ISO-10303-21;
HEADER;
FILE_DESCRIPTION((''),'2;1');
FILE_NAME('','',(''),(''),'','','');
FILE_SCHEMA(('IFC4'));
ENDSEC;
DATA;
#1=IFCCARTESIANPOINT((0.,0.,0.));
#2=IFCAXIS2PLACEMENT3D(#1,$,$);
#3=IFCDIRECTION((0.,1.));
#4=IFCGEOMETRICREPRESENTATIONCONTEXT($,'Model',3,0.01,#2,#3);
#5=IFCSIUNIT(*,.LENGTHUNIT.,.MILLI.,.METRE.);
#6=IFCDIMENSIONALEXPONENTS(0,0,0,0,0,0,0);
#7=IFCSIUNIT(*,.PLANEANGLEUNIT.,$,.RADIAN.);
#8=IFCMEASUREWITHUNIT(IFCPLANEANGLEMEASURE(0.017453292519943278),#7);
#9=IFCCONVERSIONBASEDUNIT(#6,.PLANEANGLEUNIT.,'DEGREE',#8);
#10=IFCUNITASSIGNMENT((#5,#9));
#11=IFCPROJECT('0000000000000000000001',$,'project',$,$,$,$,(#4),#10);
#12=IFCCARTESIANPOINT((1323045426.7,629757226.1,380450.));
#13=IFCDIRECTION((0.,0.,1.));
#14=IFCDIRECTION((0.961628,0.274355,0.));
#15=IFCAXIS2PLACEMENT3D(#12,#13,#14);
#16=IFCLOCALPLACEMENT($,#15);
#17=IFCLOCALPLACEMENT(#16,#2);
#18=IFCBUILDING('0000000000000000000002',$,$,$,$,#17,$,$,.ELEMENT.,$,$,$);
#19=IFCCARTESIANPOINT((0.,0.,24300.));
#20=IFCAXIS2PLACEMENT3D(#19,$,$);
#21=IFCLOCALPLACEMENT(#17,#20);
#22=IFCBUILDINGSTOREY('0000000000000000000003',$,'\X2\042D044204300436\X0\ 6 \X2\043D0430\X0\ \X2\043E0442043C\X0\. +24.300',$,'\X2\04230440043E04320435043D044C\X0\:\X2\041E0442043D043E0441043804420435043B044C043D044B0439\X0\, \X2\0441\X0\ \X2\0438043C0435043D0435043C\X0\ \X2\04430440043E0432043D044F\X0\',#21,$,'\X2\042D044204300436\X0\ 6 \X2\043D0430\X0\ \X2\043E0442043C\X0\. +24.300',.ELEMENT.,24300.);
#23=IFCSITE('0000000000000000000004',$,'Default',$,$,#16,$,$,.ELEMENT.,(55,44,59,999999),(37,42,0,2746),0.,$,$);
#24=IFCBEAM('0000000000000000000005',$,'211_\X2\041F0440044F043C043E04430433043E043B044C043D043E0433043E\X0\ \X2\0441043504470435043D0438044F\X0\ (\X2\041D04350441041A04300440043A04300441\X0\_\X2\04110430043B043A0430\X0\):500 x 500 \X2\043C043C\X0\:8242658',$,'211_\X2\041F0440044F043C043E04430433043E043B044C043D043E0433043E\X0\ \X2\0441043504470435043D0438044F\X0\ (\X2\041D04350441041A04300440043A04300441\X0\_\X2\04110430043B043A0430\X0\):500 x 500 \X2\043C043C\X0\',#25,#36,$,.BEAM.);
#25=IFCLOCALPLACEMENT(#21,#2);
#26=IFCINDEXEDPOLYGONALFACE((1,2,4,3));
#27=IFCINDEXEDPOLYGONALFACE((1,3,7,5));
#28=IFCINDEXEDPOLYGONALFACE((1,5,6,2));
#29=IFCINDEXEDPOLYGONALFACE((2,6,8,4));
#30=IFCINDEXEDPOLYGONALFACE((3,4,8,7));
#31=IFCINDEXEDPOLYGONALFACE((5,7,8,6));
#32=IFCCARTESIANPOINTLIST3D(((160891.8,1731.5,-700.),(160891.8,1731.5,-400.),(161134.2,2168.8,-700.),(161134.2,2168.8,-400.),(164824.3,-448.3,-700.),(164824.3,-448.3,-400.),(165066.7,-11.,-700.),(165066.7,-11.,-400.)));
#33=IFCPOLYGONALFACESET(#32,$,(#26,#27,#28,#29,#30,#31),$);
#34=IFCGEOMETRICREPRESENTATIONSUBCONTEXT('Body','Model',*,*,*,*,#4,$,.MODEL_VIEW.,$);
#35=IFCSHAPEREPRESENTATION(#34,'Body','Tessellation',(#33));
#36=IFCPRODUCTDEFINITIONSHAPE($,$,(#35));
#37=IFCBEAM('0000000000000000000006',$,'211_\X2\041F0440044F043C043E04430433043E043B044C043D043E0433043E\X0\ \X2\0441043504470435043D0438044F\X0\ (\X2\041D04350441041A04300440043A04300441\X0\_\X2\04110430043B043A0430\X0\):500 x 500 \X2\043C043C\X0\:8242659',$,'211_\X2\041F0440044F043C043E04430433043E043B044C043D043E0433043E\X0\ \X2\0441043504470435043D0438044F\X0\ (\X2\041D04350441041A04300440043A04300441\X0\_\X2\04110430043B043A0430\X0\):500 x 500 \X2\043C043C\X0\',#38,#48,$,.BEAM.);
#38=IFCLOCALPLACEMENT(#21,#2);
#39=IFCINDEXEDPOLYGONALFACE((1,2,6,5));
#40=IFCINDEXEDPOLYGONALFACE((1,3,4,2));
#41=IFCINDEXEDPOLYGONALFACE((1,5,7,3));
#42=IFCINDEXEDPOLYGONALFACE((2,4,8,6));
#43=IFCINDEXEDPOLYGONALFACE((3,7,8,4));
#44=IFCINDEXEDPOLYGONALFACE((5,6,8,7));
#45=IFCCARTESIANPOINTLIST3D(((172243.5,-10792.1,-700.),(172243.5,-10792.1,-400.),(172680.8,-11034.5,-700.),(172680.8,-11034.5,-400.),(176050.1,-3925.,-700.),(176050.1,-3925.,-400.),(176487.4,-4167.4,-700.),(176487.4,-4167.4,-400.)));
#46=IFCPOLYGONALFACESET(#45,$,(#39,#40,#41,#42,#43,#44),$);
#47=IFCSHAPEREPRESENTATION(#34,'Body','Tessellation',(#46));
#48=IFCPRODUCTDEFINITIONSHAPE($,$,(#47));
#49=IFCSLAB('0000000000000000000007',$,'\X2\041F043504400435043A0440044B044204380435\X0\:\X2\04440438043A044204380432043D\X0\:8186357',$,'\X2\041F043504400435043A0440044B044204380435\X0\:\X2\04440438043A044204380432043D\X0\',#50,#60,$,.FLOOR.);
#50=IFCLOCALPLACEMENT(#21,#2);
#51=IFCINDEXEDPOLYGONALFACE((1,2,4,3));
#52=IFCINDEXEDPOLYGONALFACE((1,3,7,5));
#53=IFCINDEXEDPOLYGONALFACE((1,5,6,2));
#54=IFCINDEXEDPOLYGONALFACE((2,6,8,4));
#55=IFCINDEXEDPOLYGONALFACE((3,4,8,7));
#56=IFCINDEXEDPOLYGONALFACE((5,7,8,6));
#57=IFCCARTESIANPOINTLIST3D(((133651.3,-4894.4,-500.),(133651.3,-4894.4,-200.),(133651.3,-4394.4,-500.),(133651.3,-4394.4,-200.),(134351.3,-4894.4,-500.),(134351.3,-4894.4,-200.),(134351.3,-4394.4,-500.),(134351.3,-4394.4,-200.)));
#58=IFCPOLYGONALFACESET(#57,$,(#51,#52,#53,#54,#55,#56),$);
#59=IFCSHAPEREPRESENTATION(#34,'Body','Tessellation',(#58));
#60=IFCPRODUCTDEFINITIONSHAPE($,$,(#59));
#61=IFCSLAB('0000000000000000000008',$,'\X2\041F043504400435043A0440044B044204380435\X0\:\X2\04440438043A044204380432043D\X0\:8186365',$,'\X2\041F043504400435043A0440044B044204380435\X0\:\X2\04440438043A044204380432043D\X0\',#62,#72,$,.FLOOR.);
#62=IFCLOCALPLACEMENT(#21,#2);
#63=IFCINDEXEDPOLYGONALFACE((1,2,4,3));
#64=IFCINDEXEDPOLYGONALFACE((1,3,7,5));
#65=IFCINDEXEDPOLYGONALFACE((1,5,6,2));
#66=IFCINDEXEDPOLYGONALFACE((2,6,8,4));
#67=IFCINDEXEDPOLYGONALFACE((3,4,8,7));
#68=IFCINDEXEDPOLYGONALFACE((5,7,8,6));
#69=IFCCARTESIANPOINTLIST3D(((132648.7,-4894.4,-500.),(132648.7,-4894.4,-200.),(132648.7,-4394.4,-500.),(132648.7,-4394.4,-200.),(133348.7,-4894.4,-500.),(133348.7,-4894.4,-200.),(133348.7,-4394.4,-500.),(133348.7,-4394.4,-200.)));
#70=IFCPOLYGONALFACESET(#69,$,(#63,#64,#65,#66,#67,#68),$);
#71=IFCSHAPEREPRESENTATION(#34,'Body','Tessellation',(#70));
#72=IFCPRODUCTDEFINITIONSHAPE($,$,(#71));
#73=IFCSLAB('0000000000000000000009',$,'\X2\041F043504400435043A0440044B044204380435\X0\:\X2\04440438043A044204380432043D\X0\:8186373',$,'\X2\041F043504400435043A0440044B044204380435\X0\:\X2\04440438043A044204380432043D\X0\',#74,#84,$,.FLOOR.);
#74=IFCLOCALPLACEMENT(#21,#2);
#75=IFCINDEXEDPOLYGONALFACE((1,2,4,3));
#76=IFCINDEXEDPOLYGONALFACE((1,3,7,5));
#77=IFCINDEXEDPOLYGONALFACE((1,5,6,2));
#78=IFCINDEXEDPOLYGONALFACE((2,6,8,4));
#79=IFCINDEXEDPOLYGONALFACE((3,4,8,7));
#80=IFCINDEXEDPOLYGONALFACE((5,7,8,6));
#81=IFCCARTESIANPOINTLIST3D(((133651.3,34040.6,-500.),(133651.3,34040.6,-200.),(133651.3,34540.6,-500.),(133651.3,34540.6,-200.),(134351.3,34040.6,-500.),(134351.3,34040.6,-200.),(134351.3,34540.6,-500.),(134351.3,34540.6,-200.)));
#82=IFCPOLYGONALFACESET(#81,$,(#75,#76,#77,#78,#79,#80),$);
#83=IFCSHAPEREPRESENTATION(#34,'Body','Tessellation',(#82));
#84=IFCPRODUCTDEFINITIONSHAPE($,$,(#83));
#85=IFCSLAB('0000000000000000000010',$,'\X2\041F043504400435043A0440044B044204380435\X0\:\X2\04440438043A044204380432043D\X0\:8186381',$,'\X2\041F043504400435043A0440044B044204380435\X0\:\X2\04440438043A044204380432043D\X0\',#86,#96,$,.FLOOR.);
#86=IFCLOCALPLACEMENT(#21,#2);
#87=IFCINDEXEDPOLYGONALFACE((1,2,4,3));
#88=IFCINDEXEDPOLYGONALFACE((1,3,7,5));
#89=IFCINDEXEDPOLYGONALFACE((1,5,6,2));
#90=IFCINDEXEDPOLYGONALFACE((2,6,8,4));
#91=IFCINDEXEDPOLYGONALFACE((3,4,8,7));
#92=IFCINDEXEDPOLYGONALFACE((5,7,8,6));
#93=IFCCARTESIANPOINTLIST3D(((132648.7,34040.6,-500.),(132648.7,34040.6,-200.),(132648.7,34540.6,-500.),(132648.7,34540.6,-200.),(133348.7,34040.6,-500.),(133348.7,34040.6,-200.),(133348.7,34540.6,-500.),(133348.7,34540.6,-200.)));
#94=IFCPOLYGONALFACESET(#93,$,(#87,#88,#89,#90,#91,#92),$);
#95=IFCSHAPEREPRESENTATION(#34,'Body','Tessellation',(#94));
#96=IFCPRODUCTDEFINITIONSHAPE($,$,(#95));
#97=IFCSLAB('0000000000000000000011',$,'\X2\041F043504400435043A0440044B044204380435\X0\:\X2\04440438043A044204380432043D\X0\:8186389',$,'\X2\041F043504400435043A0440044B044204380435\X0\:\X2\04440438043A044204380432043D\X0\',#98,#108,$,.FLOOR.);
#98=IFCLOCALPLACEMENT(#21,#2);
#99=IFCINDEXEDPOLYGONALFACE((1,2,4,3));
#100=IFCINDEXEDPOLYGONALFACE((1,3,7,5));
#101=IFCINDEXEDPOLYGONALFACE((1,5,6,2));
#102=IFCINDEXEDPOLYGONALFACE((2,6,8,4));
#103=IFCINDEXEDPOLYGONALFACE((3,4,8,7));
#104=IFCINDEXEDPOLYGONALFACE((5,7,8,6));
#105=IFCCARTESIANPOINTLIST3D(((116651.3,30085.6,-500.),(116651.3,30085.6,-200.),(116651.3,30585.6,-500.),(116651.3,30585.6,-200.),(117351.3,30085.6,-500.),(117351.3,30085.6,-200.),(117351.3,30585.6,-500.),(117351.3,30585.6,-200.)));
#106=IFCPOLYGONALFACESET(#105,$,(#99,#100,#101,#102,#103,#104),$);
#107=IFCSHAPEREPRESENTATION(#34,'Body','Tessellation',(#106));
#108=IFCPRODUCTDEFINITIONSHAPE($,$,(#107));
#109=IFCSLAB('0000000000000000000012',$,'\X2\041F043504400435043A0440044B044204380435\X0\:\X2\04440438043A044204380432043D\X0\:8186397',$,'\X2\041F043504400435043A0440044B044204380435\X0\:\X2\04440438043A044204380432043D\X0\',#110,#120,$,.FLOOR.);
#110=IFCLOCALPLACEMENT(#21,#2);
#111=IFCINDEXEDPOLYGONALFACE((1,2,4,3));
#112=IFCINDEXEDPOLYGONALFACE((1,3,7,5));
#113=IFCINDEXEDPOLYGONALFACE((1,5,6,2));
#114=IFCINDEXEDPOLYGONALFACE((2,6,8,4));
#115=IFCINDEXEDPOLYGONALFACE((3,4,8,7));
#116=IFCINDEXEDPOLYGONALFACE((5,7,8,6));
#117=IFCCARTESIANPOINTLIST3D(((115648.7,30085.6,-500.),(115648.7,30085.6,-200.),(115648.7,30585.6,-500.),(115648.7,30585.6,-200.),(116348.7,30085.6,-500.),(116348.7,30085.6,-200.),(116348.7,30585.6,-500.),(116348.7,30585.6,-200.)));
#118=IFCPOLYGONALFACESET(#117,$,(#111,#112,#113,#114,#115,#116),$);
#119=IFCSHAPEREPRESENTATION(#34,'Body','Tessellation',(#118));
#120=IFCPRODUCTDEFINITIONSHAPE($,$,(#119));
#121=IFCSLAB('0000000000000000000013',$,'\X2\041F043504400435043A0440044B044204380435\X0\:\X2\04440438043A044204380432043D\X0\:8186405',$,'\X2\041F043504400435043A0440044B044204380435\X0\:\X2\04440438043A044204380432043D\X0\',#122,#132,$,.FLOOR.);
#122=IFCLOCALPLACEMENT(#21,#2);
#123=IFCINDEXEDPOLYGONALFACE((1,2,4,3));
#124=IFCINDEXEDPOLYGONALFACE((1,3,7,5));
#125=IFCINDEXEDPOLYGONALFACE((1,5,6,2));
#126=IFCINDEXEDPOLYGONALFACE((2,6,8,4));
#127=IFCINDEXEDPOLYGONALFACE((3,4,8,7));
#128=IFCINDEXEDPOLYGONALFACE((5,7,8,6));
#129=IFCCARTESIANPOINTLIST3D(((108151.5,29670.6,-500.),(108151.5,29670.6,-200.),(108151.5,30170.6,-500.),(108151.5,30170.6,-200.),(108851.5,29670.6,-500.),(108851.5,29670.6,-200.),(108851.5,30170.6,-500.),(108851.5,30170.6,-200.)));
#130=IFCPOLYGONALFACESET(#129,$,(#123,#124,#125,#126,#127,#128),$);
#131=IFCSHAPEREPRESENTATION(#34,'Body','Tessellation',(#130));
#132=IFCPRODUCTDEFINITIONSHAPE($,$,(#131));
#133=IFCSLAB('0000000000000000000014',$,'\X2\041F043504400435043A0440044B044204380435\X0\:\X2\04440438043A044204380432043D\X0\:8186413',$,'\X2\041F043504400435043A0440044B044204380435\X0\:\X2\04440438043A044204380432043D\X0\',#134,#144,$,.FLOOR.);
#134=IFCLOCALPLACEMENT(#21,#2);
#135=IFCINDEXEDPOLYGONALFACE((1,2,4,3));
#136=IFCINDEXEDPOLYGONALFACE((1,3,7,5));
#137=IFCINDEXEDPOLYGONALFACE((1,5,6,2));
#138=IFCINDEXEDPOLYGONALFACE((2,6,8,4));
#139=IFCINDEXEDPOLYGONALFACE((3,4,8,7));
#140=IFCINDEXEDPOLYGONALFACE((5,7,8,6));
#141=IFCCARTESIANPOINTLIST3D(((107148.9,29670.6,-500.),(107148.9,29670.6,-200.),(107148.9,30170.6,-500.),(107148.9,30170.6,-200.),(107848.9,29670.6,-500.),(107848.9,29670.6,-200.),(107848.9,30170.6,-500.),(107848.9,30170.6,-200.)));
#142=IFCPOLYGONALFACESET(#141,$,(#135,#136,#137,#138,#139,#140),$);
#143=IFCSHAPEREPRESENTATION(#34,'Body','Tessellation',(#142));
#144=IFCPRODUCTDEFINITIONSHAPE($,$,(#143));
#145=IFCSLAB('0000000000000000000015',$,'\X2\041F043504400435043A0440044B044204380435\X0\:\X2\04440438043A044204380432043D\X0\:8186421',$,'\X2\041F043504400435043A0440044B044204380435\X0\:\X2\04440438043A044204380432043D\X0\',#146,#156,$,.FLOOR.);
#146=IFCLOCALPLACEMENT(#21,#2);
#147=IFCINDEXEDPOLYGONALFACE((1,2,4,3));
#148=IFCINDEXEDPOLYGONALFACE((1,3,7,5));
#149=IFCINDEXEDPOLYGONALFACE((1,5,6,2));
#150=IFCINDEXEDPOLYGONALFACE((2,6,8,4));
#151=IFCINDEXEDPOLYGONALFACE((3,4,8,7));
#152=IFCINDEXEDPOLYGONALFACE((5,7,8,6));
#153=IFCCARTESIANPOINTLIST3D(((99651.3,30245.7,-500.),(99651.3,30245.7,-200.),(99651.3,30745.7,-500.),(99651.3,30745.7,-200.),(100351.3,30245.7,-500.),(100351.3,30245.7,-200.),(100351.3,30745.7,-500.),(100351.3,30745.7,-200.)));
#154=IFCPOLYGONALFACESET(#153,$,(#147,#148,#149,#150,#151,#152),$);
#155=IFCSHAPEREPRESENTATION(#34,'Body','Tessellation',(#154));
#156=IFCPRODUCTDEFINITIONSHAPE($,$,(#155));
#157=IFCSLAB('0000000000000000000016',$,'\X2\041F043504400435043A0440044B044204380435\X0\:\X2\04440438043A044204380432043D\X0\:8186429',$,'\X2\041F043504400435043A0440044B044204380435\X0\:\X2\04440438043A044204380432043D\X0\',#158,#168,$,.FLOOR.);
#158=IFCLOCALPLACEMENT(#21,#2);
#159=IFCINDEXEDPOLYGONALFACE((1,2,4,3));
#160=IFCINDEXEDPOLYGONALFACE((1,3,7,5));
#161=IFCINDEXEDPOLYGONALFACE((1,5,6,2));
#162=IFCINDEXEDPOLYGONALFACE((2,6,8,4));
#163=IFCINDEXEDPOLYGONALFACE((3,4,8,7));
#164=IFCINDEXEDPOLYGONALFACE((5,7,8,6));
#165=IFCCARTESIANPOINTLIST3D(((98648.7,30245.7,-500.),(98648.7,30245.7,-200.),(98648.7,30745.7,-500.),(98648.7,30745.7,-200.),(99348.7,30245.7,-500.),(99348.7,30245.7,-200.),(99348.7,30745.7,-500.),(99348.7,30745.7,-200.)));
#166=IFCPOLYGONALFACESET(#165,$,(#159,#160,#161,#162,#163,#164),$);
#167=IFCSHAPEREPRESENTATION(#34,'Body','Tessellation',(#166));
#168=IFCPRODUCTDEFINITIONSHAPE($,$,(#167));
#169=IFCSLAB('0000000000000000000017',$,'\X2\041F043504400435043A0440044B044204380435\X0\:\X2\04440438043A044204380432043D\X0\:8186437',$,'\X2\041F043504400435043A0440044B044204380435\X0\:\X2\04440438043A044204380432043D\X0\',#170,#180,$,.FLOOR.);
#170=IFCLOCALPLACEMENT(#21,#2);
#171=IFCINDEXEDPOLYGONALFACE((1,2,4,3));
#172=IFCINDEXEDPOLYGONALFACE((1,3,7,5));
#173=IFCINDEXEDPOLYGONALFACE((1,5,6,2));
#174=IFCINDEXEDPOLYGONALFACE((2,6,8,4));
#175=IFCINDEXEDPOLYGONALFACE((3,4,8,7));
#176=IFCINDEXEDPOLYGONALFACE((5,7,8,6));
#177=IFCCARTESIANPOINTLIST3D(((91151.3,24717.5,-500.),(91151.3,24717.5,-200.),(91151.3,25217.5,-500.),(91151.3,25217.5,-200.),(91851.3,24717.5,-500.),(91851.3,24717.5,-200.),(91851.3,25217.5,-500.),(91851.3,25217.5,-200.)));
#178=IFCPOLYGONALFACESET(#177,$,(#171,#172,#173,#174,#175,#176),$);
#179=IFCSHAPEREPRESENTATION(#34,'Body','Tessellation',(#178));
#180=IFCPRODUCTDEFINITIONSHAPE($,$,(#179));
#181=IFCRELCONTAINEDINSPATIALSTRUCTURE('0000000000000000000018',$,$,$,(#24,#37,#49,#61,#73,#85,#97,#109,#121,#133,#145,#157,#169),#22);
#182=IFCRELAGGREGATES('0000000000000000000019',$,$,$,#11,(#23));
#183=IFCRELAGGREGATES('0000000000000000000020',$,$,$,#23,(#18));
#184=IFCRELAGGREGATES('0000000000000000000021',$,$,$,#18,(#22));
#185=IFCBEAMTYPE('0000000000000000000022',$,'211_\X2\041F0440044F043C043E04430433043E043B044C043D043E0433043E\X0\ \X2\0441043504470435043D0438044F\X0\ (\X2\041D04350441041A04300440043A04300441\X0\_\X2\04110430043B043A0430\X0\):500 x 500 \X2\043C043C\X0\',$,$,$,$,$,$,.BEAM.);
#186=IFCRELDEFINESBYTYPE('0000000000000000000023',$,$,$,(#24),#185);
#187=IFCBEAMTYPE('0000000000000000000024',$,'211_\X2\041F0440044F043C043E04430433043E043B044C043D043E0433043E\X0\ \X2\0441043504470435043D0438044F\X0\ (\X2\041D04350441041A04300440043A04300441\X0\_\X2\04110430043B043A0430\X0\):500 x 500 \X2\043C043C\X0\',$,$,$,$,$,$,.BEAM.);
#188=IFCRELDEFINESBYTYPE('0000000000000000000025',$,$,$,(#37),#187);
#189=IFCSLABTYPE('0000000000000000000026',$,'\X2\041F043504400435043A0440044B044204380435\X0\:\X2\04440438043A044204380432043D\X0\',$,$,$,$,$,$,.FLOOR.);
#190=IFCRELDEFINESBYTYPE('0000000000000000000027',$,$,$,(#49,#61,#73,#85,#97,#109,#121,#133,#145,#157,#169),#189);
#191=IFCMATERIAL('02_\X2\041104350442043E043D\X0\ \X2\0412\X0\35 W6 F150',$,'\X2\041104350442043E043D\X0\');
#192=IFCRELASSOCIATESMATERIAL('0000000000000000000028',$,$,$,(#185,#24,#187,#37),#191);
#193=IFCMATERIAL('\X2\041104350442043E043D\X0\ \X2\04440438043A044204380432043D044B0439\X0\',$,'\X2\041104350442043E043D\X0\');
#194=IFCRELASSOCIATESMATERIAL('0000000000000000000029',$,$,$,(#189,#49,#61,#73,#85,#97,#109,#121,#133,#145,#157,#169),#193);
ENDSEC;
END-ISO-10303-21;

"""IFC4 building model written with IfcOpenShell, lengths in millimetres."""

from ifc_helpers import new_model, entity, si_unit, converted_unit, direction, frame, origin, place, context, subcontext, project, spatial, indexed_curve, outline, extrude, source, transform, mapped, material, type_object, type_shapes, element, save


model = new_model("IFC4")

# Units and contexts
model_context = context("Model", 3, precision=0.01, world=origin(), true_north=direction((0.0, 1.0)))
body_context = subcontext(model_context, "Body", "Model", "MODEL_VIEW")
ifc_project = project(units=[si_unit("LENGTHUNIT", "METRE", prefix="MILLI"), converted_unit("PLANEANGLEUNIT", "DEGREE", entity("IfcPlaneAngleMeasure", 0.017453292519943278), si_unit("PLANEANGLEUNIT", "RADIAN"), dimensions=[0, 0, 0, 0, 0, 0, 0])], contexts=[model_context])

# Site, building, storey
site_placement = place(None, frame((1323045426.7, 629757226.1, 380450.0), z_axis=(0.0, 0.0, 1.0), x_axis=(0.961628, 0.274355, 0.0)))
site = spatial("IfcSite", under=ifc_project, at=site_placement, Name="Default", CompositionType="ELEMENT", RefLatitude=(55, 44, 59, 999999), RefLongitude=(37, 42, 0, 2746), RefElevation=0.0)
building_placement = place(site_placement, origin())
building = spatial("IfcBuilding", under=site, at=building_placement, CompositionType="ELEMENT")
storey_placement = place(building_placement, frame((0.0, 0.0, 24300.0)))
storey = spatial("IfcBuildingStorey", under=building, at=storey_placement, Name="Этаж 6 на отм. +24.300", ObjectType="Уровень:Относительный, с именем уровня", LongName="Этаж 6 на отм. +24.300", CompositionType="ELEMENT", Elevation=24300.0)

# Beams
ifc_material_1 = material(Name="02_Бетон В35 W6 F150", Category="Бетон")
beam_type_1 = type_object("IfcBeamType", Name="211_Прямоугольного сечения (НесКаркас_Балка):500 x 500 мм", PredefinedType="BEAM", material=ifc_material_1)
shared_shape_1 = source(origin(), body_context, "Body", "SweptSolid", [
    extrude(outline(indexed_curve([(-150.0, -250.0), (150.0, -250.0), (150.0, 250.0), (-150.0, 250.0), (-150.0, -250.0)], self_intersect=False)), frame((161013.0, 1950.2, 23750.0), z_axis=(0.87462, -0.48481, 0.0), x_axis=(0.0, 0.0, -1.0)), (0.0, 0.0, 1.0), 4496.2),
])
type_shapes(beam_type_1, [shared_shape_1])
beam_1_placement = place(storey_placement, frame((0.0, 0.0, -24300.0)))
element("IfcBeam", 1, at=beam_1_placement, inside=storey, type_object=beam_type_1, material=ifc_material_1, Name="211_Прямоугольного сечения (НесКаркас_Балка):500 x 500 мм:8242658", ObjectType="211_Прямоугольного сечения (НесКаркас_Балка):500 x 500 мм", PredefinedType="BEAM", context=body_context, shape_type="MappedRepresentation", body=[
    mapped(shared_shape_1, transform((0.0, 0.0, 0.0), scale=1.0)),
])
beam_type_2 = type_object("IfcBeamType", Name="211_Прямоугольного сечения (НесКаркас_Балка):500 x 500 мм", PredefinedType="BEAM", material=ifc_material_1)
shared_shape_2 = source(origin(), body_context, "Body", "SweptSolid", [
    extrude(outline(indexed_curve([(-150.0, -250.0), (150.0, -250.0), (150.0, 250.0), (-150.0, 250.0), (-150.0, -250.0)], self_intersect=False)), frame((176268.7, -4046.2, 23750.0), z_axis=(-0.48481, -0.87462, 0.0), x_axis=(0.0, 0.0, -1.0)), (0.0, 0.0, 1.0), 7851.6),
])
type_shapes(beam_type_2, [shared_shape_2])
beam_2_placement = place(storey_placement, frame((0.0, 0.0, -24300.0)))
element("IfcBeam", 2, at=beam_2_placement, inside=storey, type_object=beam_type_2, material=ifc_material_1, Name="211_Прямоугольного сечения (НесКаркас_Балка):500 x 500 мм:8242659", ObjectType="211_Прямоугольного сечения (НесКаркас_Балка):500 x 500 мм", PredefinedType="BEAM", context=body_context, shape_type="MappedRepresentation", body=[
    mapped(shared_shape_2, transform((0.0, 0.0, 0.0), scale=1.0)),
])

# Slabs
ifc_material_2 = material(Name="Бетон фиктивный", Category="Бетон")
slab_type_1 = type_object("IfcSlabType", Name="Перекрытие:фиктивн", PredefinedType="FLOOR", material=ifc_material_2)
slab_1_placement = place(storey_placement, origin())
element("IfcSlab", 3, at=slab_1_placement, inside=storey, type_object=slab_type_1, material=ifc_material_2, Name="Перекрытие:фиктивн:8186357", ObjectType="Перекрытие:фиктивн", PredefinedType="FLOOR", context=body_context, shape_type="SweptSolid", body=[
    extrude(outline(indexed_curve([(-250.0, -350.0), (250.0, -350.0), (250.0, 350.0), (-250.0, 350.0), (-250.0, -350.0)], self_intersect=False)), frame((134001.3, -4644.4, -200.0), z_axis=(0.0, 0.0, -1.0), x_axis=(0.0, 1.0, 0.0)), (0.0, 0.0, 1.0), 300.0),
])
slab_2_placement = place(storey_placement, origin())
element("IfcSlab", 4, at=slab_2_placement, inside=storey, type_object=slab_type_1, material=ifc_material_2, Name="Перекрытие:фиктивн:8186365", ObjectType="Перекрытие:фиктивн", PredefinedType="FLOOR", context=body_context, shape_type="SweptSolid", body=[
    extrude(outline(indexed_curve([(-250.0, -350.0), (250.0, -350.0), (250.0, 350.0), (-250.0, 350.0), (-250.0, -350.0)], self_intersect=False)), frame((132998.7, -4644.4, -200.0), z_axis=(0.0, 0.0, -1.0), x_axis=(0.0, 1.0, 0.0)), (0.0, 0.0, 1.0), 300.0),
])
slab_3_placement = place(storey_placement, origin())
element("IfcSlab", 5, at=slab_3_placement, inside=storey, type_object=slab_type_1, material=ifc_material_2, Name="Перекрытие:фиктивн:8186373", ObjectType="Перекрытие:фиктивн", PredefinedType="FLOOR", context=body_context, shape_type="SweptSolid", body=[
    extrude(outline(indexed_curve([(-250.0, -350.0), (250.0, -350.0), (250.0, 350.0), (-250.0, 350.0), (-250.0, -350.0)], self_intersect=False)), frame((134001.3, 34290.6, -200.0), z_axis=(0.0, 0.0, -1.0), x_axis=(0.0, 1.0, 0.0)), (0.0, 0.0, 1.0), 300.0),
])
slab_4_placement = place(storey_placement, origin())
element("IfcSlab", 6, at=slab_4_placement, inside=storey, type_object=slab_type_1, material=ifc_material_2, Name="Перекрытие:фиктивн:8186381", ObjectType="Перекрытие:фиктивн", PredefinedType="FLOOR", context=body_context, shape_type="SweptSolid", body=[
    extrude(outline(indexed_curve([(-250.0, -350.0), (250.0, -350.0), (250.0, 350.0), (-250.0, 350.0), (-250.0, -350.0)], self_intersect=False)), frame((132998.7, 34290.6, -200.0), z_axis=(0.0, 0.0, -1.0), x_axis=(0.0, 1.0, 0.0)), (0.0, 0.0, 1.0), 300.0),
])
slab_5_placement = place(storey_placement, origin())
element("IfcSlab", 7, at=slab_5_placement, inside=storey, type_object=slab_type_1, material=ifc_material_2, Name="Перекрытие:фиктивн:8186389", ObjectType="Перекрытие:фиктивн", PredefinedType="FLOOR", context=body_context, shape_type="SweptSolid", body=[
    extrude(outline(indexed_curve([(-250.0, -350.0), (250.0, -350.0), (250.0, 350.0), (-250.0, 350.0), (-250.0, -350.0)], self_intersect=False)), frame((117001.3, 30335.6, -200.0), z_axis=(0.0, 0.0, -1.0), x_axis=(0.0, 1.0, 0.0)), (0.0, 0.0, 1.0), 300.0),
])
slab_6_placement = place(storey_placement, origin())
element("IfcSlab", 8, at=slab_6_placement, inside=storey, type_object=slab_type_1, material=ifc_material_2, Name="Перекрытие:фиктивн:8186397", ObjectType="Перекрытие:фиктивн", PredefinedType="FLOOR", context=body_context, shape_type="SweptSolid", body=[
    extrude(outline(indexed_curve([(-250.0, -350.0), (250.0, -350.0), (250.0, 350.0), (-250.0, 350.0), (-250.0, -350.0)], self_intersect=False)), frame((115998.7, 30335.6, -200.0), z_axis=(0.0, 0.0, -1.0), x_axis=(0.0, 1.0, 0.0)), (0.0, 0.0, 1.0), 300.0),
])
slab_7_placement = place(storey_placement, origin())
element("IfcSlab", 9, at=slab_7_placement, inside=storey, type_object=slab_type_1, material=ifc_material_2, Name="Перекрытие:фиктивн:8186405", ObjectType="Перекрытие:фиктивн", PredefinedType="FLOOR", context=body_context, shape_type="SweptSolid", body=[
    extrude(outline(indexed_curve([(-250.0, -350.0), (250.0, -350.0), (250.0, 350.0), (-250.0, 350.0), (-250.0, -350.0)], self_intersect=False)), frame((108501.5, 29920.6, -200.0), z_axis=(0.0, 0.0, -1.0), x_axis=(0.0, 1.0, 0.0)), (0.0, 0.0, 1.0), 300.0),
])
slab_8_placement = place(storey_placement, origin())
element("IfcSlab", 10, at=slab_8_placement, inside=storey, type_object=slab_type_1, material=ifc_material_2, Name="Перекрытие:фиктивн:8186413", ObjectType="Перекрытие:фиктивн", PredefinedType="FLOOR", context=body_context, shape_type="SweptSolid", body=[
    extrude(outline(indexed_curve([(-250.0, -350.0), (250.0, -350.0), (250.0, 350.0), (-250.0, 350.0), (-250.0, -350.0)], self_intersect=False)), frame((107498.9, 29920.6, -200.0), z_axis=(0.0, 0.0, -1.0), x_axis=(0.0, 1.0, 0.0)), (0.0, 0.0, 1.0), 300.0),
])
slab_9_placement = place(storey_placement, origin())
element("IfcSlab", 11, at=slab_9_placement, inside=storey, type_object=slab_type_1, material=ifc_material_2, Name="Перекрытие:фиктивн:8186421", ObjectType="Перекрытие:фиктивн", PredefinedType="FLOOR", context=body_context, shape_type="SweptSolid", body=[
    extrude(outline(indexed_curve([(-250.0, -350.0), (250.0, -350.0), (250.0, 350.0), (-250.0, 350.0), (-250.0, -350.0)], self_intersect=False)), frame((100001.3, 30495.7, -200.0), z_axis=(0.0, 0.0, -1.0), x_axis=(0.0, 1.0, 0.0)), (0.0, 0.0, 1.0), 300.0),
])
slab_10_placement = place(storey_placement, origin())
element("IfcSlab", 12, at=slab_10_placement, inside=storey, type_object=slab_type_1, material=ifc_material_2, Name="Перекрытие:фиктивн:8186429", ObjectType="Перекрытие:фиктивн", PredefinedType="FLOOR", context=body_context, shape_type="SweptSolid", body=[
    extrude(outline(indexed_curve([(-250.0, -350.0), (250.0, -350.0), (250.0, 350.0), (-250.0, 350.0), (-250.0, -350.0)], self_intersect=False)), frame((98998.7, 30495.7, -200.0), z_axis=(0.0, 0.0, -1.0), x_axis=(0.0, 1.0, 0.0)), (0.0, 0.0, 1.0), 300.0),
])
slab_11_placement = place(storey_placement, origin())
element("IfcSlab", 13, at=slab_11_placement, inside=storey, type_object=slab_type_1, material=ifc_material_2, Name="Перекрытие:фиктивн:8186437", ObjectType="Перекрытие:фиктивн", PredefinedType="FLOOR", context=body_context, shape_type="SweptSolid", body=[
    extrude(outline(indexed_curve([(-250.0, -350.0), (250.0, -350.0), (250.0, 350.0), (-250.0, 350.0), (-250.0, -350.0)], self_intersect=False)), frame((91501.3, 24967.5, -200.0), z_axis=(0.0, 0.0, -1.0), x_axis=(0.0, 1.0, 0.0)), (0.0, 0.0, 1.0), 300.0),
])

save(model, "model.ifc")
